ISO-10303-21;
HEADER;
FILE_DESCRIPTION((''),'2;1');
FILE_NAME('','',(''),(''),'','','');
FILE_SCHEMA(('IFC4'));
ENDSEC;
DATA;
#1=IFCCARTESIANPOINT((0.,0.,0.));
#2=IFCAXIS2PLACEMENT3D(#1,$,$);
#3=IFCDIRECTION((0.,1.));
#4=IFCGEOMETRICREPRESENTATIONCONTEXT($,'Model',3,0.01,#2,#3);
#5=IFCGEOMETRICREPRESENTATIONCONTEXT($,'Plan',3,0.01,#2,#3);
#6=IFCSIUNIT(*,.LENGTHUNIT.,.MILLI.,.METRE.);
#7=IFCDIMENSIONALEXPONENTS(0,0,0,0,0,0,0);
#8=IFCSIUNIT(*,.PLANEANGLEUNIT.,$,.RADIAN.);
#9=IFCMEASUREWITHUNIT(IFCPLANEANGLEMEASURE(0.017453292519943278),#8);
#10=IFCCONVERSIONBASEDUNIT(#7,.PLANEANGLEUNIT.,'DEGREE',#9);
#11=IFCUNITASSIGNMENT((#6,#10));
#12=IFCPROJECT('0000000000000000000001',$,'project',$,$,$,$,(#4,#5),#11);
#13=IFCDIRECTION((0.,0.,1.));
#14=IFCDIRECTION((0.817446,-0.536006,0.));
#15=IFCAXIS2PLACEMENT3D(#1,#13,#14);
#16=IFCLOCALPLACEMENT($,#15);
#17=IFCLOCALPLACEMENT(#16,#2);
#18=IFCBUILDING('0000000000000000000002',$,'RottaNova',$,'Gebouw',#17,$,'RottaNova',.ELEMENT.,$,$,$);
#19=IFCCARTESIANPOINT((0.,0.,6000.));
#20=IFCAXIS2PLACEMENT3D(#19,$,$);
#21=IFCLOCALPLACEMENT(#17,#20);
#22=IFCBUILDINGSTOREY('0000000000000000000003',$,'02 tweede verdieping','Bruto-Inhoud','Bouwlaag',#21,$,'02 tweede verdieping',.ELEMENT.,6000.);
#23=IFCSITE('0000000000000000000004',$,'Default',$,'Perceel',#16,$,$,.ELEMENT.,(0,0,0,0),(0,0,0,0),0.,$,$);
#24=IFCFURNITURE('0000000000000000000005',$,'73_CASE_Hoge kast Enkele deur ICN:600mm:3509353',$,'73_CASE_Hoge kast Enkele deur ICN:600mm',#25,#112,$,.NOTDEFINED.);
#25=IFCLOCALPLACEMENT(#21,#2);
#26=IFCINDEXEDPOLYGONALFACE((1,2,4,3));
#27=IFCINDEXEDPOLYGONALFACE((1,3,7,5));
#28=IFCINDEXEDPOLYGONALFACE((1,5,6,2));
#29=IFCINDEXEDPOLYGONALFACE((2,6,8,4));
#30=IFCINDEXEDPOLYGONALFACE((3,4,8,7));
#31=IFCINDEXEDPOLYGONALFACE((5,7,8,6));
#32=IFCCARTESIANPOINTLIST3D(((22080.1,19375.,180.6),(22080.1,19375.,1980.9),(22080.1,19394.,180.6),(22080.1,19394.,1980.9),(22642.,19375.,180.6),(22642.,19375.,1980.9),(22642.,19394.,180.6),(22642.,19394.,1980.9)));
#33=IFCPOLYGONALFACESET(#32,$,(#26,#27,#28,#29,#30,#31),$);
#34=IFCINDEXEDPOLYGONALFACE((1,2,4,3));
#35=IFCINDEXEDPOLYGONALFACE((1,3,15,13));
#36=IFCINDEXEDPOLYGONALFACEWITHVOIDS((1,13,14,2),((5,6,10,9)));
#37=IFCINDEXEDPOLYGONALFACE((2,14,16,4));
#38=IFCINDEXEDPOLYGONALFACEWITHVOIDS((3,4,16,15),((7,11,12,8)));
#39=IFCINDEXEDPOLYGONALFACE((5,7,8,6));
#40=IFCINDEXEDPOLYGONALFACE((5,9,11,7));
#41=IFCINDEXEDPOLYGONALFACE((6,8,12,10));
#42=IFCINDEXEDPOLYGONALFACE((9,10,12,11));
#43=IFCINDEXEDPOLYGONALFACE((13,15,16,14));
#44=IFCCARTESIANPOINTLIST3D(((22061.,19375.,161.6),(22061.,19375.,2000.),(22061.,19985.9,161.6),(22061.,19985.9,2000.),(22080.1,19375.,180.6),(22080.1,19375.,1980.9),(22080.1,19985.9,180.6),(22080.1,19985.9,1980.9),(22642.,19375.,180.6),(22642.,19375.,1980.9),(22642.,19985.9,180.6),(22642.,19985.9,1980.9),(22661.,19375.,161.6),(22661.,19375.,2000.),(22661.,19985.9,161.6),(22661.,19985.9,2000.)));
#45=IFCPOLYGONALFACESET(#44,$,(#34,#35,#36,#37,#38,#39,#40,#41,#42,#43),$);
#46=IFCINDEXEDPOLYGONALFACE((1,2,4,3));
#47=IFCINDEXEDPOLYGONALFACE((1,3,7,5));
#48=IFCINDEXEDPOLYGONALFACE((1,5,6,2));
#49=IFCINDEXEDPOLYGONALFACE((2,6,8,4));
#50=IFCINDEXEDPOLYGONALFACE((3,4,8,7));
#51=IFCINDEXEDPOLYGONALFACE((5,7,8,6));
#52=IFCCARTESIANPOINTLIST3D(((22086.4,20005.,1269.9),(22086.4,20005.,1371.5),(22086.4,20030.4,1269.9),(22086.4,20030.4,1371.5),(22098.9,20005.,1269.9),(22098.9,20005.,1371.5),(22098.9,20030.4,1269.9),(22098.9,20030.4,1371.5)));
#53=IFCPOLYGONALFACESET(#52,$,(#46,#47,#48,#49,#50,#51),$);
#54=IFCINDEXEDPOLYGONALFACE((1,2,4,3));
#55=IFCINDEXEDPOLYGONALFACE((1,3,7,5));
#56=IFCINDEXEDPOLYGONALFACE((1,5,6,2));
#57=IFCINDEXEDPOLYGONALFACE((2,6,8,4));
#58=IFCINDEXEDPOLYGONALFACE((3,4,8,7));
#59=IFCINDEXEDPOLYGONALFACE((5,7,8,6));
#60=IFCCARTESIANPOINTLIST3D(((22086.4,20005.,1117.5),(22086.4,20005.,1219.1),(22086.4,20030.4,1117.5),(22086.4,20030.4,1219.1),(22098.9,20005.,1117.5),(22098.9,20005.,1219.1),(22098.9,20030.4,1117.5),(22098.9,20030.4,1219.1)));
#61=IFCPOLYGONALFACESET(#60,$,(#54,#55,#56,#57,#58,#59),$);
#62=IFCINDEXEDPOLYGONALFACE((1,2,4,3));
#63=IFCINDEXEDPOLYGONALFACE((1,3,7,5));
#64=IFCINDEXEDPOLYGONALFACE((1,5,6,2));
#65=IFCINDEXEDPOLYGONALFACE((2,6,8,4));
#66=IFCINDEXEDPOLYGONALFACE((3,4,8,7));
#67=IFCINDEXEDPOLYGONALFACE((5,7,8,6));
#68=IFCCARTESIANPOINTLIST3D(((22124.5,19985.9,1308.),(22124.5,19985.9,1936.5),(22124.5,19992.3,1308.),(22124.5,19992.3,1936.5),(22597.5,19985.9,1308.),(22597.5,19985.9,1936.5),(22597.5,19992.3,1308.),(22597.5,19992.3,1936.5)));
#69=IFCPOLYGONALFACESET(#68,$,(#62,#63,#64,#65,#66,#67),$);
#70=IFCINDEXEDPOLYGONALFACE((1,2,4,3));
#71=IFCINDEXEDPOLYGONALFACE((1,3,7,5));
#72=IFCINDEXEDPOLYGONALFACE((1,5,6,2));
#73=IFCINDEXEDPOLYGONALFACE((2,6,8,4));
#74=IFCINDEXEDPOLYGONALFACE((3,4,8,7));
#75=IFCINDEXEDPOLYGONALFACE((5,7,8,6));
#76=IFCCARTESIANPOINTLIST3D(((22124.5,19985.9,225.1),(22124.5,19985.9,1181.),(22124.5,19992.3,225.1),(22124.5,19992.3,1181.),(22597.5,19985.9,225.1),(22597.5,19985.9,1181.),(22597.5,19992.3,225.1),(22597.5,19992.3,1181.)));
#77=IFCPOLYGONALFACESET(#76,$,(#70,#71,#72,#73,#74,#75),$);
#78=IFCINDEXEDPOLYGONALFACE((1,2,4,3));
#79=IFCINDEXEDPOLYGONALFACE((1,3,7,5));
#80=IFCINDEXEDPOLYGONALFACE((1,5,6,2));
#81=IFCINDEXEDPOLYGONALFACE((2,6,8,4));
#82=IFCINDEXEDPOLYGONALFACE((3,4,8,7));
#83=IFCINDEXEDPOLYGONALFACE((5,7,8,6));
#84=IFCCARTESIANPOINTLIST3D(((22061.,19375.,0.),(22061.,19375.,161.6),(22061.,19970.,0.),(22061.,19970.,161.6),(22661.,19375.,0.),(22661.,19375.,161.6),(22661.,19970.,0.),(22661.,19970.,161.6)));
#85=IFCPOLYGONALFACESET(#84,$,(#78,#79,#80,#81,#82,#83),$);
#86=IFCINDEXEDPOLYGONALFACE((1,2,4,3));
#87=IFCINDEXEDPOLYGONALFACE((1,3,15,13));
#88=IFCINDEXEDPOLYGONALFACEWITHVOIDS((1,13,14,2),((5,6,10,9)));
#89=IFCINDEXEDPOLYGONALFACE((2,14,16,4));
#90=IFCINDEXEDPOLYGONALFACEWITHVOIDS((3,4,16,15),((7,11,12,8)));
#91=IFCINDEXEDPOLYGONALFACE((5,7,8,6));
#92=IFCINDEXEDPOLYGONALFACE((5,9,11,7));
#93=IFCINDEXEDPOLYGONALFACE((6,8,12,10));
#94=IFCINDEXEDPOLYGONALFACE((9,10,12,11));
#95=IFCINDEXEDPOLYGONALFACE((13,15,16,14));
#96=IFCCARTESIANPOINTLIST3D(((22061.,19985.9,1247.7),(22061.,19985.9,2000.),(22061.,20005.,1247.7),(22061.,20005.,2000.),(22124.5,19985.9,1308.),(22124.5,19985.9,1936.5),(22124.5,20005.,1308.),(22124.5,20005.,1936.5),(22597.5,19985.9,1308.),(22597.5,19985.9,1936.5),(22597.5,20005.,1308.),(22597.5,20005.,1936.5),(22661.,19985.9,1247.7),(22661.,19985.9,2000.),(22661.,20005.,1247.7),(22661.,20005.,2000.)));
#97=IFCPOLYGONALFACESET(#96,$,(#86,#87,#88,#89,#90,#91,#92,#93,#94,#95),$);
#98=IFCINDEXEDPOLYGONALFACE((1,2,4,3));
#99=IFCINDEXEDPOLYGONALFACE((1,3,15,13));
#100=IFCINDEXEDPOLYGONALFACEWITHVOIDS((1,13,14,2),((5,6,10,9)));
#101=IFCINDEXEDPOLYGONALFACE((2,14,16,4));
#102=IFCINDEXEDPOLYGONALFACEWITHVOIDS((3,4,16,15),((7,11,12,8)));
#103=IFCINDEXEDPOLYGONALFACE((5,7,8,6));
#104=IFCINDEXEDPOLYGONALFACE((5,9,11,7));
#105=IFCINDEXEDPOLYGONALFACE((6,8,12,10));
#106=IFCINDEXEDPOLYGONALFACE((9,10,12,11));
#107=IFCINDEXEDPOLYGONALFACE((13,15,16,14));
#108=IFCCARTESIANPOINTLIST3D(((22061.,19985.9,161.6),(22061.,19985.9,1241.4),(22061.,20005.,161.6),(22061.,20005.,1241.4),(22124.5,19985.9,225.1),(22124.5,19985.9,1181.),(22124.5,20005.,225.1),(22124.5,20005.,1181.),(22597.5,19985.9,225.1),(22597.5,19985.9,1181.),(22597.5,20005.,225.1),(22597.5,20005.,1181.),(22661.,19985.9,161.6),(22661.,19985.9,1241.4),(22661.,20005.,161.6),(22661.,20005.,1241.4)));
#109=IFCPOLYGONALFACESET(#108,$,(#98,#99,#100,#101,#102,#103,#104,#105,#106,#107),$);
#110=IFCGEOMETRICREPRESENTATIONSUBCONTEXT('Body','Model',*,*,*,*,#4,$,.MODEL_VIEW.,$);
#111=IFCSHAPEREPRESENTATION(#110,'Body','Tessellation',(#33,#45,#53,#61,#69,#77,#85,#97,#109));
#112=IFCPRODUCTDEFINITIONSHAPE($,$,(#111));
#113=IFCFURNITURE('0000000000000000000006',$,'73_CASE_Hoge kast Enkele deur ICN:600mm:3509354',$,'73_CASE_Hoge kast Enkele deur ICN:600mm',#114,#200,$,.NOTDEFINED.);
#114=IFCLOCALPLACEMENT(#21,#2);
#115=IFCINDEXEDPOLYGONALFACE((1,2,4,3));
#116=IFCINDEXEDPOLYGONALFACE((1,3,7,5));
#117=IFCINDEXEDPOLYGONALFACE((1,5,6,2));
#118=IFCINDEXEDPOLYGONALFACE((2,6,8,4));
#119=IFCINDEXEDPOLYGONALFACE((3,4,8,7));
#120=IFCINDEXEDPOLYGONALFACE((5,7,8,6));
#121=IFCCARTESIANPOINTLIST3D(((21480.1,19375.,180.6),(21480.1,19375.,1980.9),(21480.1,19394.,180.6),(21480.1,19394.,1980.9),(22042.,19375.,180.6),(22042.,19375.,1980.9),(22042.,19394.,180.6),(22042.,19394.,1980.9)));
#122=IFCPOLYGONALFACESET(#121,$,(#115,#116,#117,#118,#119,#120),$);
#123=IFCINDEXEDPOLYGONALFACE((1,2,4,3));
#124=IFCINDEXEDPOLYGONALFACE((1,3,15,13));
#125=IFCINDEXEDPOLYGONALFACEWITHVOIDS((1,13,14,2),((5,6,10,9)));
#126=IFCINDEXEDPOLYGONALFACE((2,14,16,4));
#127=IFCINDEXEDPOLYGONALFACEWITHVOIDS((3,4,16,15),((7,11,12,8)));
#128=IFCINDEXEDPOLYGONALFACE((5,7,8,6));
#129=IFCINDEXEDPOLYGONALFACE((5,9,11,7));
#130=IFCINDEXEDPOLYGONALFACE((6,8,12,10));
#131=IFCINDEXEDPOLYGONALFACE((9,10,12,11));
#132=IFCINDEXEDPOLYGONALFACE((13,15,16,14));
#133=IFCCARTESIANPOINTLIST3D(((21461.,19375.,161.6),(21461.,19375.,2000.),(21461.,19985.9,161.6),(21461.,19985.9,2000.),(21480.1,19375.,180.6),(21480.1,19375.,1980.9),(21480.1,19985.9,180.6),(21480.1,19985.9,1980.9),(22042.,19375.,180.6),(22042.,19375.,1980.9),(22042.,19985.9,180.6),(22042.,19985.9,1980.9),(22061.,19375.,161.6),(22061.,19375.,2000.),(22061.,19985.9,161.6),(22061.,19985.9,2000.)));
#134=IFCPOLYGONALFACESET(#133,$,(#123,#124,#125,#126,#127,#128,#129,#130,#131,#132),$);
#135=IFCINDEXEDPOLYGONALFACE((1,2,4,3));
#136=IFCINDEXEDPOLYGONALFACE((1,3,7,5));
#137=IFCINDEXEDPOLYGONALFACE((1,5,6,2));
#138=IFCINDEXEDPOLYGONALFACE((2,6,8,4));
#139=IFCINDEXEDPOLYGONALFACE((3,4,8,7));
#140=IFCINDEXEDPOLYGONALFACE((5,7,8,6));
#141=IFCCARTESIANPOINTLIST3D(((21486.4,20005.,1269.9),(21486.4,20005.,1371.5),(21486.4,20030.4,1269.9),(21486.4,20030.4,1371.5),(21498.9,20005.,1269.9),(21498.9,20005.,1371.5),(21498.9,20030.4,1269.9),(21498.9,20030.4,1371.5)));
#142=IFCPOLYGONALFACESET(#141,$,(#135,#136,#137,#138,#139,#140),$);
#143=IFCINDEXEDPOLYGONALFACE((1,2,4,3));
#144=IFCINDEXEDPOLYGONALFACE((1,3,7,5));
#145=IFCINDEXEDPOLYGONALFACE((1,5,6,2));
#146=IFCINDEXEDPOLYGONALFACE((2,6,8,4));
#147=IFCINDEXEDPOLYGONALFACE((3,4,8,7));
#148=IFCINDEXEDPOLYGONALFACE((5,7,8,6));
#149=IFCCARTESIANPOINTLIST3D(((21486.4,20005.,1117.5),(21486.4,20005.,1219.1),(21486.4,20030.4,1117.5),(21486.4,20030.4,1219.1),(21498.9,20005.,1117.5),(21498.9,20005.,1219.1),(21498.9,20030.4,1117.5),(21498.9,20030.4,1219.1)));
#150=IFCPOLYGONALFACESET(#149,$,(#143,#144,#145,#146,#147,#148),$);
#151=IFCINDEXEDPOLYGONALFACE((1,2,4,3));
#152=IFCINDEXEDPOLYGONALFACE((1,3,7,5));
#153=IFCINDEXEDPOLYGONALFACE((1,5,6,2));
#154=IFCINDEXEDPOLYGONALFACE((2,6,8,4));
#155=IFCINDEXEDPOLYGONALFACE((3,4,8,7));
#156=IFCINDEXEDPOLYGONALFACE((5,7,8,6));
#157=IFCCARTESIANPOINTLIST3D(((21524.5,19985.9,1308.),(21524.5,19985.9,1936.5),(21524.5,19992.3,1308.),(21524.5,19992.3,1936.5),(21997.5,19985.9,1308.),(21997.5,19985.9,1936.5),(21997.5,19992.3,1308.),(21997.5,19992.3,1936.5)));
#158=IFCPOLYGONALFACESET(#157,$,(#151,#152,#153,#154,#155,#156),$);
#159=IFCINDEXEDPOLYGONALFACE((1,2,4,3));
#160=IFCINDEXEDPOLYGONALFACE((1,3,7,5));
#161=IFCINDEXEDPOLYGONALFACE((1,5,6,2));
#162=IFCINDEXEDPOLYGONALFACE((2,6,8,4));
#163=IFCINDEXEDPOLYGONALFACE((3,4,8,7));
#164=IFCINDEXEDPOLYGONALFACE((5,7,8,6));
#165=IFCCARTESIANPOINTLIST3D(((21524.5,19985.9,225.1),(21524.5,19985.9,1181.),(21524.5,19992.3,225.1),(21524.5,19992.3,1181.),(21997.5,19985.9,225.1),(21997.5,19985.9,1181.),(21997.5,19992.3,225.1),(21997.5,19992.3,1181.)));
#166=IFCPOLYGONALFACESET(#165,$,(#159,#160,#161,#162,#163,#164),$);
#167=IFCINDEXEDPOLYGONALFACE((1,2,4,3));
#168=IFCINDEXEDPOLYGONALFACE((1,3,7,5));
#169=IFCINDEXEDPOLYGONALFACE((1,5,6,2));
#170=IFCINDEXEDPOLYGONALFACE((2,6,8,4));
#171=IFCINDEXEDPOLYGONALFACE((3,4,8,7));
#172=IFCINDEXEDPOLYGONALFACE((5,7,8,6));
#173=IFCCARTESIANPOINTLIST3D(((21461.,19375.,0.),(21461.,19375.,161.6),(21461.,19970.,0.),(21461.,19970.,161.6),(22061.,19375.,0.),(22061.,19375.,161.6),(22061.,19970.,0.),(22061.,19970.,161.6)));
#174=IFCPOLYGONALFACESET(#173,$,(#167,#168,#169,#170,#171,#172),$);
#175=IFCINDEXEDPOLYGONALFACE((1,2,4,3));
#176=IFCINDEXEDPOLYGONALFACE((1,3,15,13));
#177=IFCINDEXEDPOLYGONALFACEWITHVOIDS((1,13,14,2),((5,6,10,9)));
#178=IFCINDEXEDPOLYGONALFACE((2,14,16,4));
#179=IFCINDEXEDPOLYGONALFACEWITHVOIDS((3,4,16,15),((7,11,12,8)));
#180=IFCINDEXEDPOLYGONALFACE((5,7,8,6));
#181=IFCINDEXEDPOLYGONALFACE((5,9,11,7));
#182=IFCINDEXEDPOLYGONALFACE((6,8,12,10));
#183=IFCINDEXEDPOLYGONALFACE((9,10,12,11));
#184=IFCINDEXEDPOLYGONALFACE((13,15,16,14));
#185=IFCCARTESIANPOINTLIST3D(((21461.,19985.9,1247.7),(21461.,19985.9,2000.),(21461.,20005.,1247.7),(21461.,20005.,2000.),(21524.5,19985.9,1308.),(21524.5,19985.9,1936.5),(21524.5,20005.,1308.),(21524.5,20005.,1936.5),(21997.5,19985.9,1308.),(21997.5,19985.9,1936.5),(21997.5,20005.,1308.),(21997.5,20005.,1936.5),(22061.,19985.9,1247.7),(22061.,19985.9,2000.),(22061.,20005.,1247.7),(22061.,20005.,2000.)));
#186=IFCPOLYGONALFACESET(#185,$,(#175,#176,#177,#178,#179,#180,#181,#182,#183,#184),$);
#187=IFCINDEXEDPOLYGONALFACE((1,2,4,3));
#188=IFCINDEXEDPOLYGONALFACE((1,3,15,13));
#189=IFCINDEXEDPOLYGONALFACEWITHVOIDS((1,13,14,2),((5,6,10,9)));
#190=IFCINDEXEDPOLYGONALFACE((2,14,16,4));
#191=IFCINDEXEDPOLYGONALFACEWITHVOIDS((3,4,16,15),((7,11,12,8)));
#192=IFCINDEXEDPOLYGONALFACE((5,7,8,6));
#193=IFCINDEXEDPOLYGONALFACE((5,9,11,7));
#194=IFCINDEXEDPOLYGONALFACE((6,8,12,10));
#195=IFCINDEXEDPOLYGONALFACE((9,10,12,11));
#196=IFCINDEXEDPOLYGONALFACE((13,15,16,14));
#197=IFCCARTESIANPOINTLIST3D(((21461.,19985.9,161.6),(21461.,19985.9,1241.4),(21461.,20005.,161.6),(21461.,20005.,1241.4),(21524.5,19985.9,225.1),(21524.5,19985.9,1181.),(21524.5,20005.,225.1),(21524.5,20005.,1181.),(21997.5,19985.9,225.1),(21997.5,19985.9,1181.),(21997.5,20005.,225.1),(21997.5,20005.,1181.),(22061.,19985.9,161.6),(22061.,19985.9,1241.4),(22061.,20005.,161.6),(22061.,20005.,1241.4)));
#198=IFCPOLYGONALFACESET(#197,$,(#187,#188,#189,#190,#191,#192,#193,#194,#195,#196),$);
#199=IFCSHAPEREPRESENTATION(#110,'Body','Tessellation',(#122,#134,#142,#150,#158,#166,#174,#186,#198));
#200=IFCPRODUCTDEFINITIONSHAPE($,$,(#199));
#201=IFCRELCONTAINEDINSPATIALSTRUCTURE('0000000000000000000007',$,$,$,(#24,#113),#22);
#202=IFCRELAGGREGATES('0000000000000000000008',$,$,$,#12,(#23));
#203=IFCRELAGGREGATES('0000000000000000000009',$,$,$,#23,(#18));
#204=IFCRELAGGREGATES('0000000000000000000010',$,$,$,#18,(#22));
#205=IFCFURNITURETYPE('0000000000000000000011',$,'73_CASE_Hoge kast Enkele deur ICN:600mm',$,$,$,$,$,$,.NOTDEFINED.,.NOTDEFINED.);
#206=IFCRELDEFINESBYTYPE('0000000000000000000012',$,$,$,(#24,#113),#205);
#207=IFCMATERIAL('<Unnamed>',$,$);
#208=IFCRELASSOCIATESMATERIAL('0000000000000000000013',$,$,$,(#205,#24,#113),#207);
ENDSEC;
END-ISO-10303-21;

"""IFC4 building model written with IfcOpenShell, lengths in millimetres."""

from ifc_helpers import new_model, entity, si_unit, converted_unit, direction, frame, origin, place, context, subcontext, project, spatial, indexed_curve, outline, extrude, source, transform, mapped, material, type_object, type_shapes, element, save


model = new_model("IFC4")

# Units and contexts
model_context = context("Model", 3, precision=0.01, world=origin(), true_north=direction((0.0, 1.0)))
plan_context = context("Plan", 3, precision=0.01, world=origin(), true_north=direction((0.0, 1.0)))
body_context = subcontext(model_context, "Body", "Model", "MODEL_VIEW")
ifc_project = project(units=[si_unit("LENGTHUNIT", "METRE", prefix="MILLI"), converted_unit("PLANEANGLEUNIT", "DEGREE", entity("IfcPlaneAngleMeasure", 0.017453292519943278), si_unit("PLANEANGLEUNIT", "RADIAN"), dimensions=[0, 0, 0, 0, 0, 0, 0])], contexts=[model_context, plan_context])

# Site, building, storey
site_placement = place(None, frame((0.0, 0.0, 0.0), z_axis=(0.0, 0.0, 1.0), x_axis=(0.817446, -0.536006, 0.0)))
site = spatial("IfcSite", under=ifc_project, at=site_placement, Name="Default", ObjectType="Perceel", CompositionType="ELEMENT", RefLatitude=(0, 0, 0, 0), RefLongitude=(0, 0, 0, 0), RefElevation=0.0)
building_placement = place(site_placement, origin())
building = spatial("IfcBuilding", under=site, at=building_placement, Name="RottaNova", ObjectType="Gebouw", LongName="RottaNova", CompositionType="ELEMENT")
storey_placement = place(building_placement, frame((0.0, 0.0, 6000.0)))
storey = spatial("IfcBuildingStorey", under=building, at=storey_placement, Name="02 tweede verdieping", Description="Bruto-Inhoud", ObjectType="Bouwlaag", LongName="02 tweede verdieping", CompositionType="ELEMENT", Elevation=6000.0)

# Furniture
ifc_material_1 = material(Name="<Unnamed>")
furniture_type = type_object("IfcFurnitureType", Name="73_CASE_Hoge kast Enkele deur ICN:600mm", AssemblyPlace="NOTDEFINED", PredefinedType="NOTDEFINED", material=ifc_material_1)
shared_shape_1 = source(origin(), body_context, "Body", "SweptSolid", [
    extrude(outline(indexed_curve([(-9.5, -280.9), (9.5, -280.9), (9.5, 280.9), (-9.5, 280.9), (-9.5, -280.9)], self_intersect=False)), frame((18.7, -9.5, 180.6), z_axis=(0.0, 0.0, 1.0), x_axis=(0.0, 1.0, 0.0)), (0.0, 0.0, 1.0), 1800.3),
    extrude(outline(indexed_curve([(-300.0, -919.2), (300.0, -919.2), (300.0, 919.2), (-300.0, 919.2), (-300.0, -919.2)], self_intersect=False), holes=[indexed_curve([(-280.9, 900.2), (281.0, 900.2), (281.0, -900.2), (-280.9, -900.2), (-280.9, 900.2)], self_intersect=False)]), frame((18.7, -610.9, 1080.8), z_axis=(0.0, 1.0, 0.0), x_axis=(-1.0, 0.0, 0.0)), (0.0, 0.0, 1.0), 610.9),
    extrude(outline(indexed_curve([(-12.7, -6.3), (12.7, -6.3), (12.7, 6.3), (-12.7, 6.3), (-12.7, -6.3)], self_intersect=False)), frame((287.1, -642.7, 1269.9), z_axis=(0.0, 0.0, 1.0), x_axis=(0.0, 1.0, 0.0)), (0.0, 0.0, 1.0), 101.6),
    extrude(outline(indexed_curve([(-12.7, -6.3), (12.7, -6.3), (12.7, 6.3), (-12.7, 6.3), (-12.7, -6.3)], self_intersect=False)), frame((287.1, -642.7, 1117.5), z_axis=(0.0, 0.0, 1.0), x_axis=(0.0, 1.0, 0.0)), (0.0, 0.0, 1.0), 101.6),
    extrude(outline(indexed_curve([(-3.2, -236.5), (3.2, -236.5), (3.2, 236.5), (-3.2, 236.5), (-3.2, -236.5)], self_intersect=False)), frame((18.7, -614.1, 1308.0), z_axis=(0.0, 0.0, 1.0), x_axis=(0.0, 1.0, 0.0)), (0.0, 0.0, 1.0), 628.5),
    extrude(outline(indexed_curve([(-3.2, -236.5), (3.2, -236.5), (3.2, 236.5), (-3.2, 236.5), (-3.2, -236.5)], self_intersect=False)), frame((18.7, -614.1, 225.1), z_axis=(0.0, 0.0, 1.0), x_axis=(0.0, 1.0, 0.0)), (0.0, 0.0, 1.0), 956.0),
    extrude(outline(indexed_curve([(-300.0, -297.5), (300.0, -297.5), (300.0, 297.5), (-300.0, 297.5), (-300.0, -297.5)], self_intersect=False)), frame((18.7, -297.5, 0.0), z_axis=(0.0, 0.0, 1.0), x_axis=(-1.0, 0.0, 0.0)), (0.0, 0.0, 1.0), 161.6),
    extrude(outline(indexed_curve([(-376.1, -300.0), (376.1, -300.0), (376.1, 300.0), (-376.1, 300.0), (-376.1, -300.0)], self_intersect=False), holes=[indexed_curve([(-312.6, -236.5), (-312.6, 236.5), (315.8, 236.5), (315.8, -236.5), (-312.6, -236.5)], self_intersect=False)]), frame((18.7, -630.0, 1623.9), z_axis=(0.0, 1.0, 0.0), x_axis=(0.0, 0.0, -1.0)), (0.0, 0.0, 1.0), 19.1),
    extrude(outline(indexed_curve([(-300.0, -539.9), (300.0, -539.9), (300.0, 539.9), (-300.0, 539.9), (-300.0, -539.9)], self_intersect=False), holes=[indexed_curve([(-236.5, 479.6), (236.5, 479.6), (236.5, -476.4), (-236.5, -476.4), (-236.5, 479.6)], self_intersect=False)]), frame((18.7, -630.0, 701.5), z_axis=(0.0, 1.0, 0.0), x_axis=(-1.0, 0.0, 0.0)), (0.0, 0.0, 1.0), 19.1),
])
type_shapes(furniture_type, [shared_shape_1])
for number, where, z_axis, x_axis, name in (
    (1, (22379.7, 19375.0, 0.0), (0.0, 0.0, 1.0), (-1.0, 0.0, 0.0), "73_CASE_Hoge kast Enkele deur ICN:600mm:3509353"),
    (2, (21779.7, 19375.0, 0.0), (0.0, 0.0, 1.0), (-1.0, 0.0, 0.0), "73_CASE_Hoge kast Enkele deur ICN:600mm:3509354"),
):
    element("IfcFurniture", number, at=place(storey_placement, frame(where, z_axis=z_axis, x_axis=x_axis)), inside=storey, type_object=furniture_type, material=ifc_material_1, Name=name, ObjectType="73_CASE_Hoge kast Enkele deur ICN:600mm", PredefinedType="NOTDEFINED", context=body_context, shape_type="MappedRepresentation", body=[
        mapped(shared_shape_1, transform((0.0, 0.0, 0.0), scale=1.0)),
    ])

save(model, "model.ifc")
